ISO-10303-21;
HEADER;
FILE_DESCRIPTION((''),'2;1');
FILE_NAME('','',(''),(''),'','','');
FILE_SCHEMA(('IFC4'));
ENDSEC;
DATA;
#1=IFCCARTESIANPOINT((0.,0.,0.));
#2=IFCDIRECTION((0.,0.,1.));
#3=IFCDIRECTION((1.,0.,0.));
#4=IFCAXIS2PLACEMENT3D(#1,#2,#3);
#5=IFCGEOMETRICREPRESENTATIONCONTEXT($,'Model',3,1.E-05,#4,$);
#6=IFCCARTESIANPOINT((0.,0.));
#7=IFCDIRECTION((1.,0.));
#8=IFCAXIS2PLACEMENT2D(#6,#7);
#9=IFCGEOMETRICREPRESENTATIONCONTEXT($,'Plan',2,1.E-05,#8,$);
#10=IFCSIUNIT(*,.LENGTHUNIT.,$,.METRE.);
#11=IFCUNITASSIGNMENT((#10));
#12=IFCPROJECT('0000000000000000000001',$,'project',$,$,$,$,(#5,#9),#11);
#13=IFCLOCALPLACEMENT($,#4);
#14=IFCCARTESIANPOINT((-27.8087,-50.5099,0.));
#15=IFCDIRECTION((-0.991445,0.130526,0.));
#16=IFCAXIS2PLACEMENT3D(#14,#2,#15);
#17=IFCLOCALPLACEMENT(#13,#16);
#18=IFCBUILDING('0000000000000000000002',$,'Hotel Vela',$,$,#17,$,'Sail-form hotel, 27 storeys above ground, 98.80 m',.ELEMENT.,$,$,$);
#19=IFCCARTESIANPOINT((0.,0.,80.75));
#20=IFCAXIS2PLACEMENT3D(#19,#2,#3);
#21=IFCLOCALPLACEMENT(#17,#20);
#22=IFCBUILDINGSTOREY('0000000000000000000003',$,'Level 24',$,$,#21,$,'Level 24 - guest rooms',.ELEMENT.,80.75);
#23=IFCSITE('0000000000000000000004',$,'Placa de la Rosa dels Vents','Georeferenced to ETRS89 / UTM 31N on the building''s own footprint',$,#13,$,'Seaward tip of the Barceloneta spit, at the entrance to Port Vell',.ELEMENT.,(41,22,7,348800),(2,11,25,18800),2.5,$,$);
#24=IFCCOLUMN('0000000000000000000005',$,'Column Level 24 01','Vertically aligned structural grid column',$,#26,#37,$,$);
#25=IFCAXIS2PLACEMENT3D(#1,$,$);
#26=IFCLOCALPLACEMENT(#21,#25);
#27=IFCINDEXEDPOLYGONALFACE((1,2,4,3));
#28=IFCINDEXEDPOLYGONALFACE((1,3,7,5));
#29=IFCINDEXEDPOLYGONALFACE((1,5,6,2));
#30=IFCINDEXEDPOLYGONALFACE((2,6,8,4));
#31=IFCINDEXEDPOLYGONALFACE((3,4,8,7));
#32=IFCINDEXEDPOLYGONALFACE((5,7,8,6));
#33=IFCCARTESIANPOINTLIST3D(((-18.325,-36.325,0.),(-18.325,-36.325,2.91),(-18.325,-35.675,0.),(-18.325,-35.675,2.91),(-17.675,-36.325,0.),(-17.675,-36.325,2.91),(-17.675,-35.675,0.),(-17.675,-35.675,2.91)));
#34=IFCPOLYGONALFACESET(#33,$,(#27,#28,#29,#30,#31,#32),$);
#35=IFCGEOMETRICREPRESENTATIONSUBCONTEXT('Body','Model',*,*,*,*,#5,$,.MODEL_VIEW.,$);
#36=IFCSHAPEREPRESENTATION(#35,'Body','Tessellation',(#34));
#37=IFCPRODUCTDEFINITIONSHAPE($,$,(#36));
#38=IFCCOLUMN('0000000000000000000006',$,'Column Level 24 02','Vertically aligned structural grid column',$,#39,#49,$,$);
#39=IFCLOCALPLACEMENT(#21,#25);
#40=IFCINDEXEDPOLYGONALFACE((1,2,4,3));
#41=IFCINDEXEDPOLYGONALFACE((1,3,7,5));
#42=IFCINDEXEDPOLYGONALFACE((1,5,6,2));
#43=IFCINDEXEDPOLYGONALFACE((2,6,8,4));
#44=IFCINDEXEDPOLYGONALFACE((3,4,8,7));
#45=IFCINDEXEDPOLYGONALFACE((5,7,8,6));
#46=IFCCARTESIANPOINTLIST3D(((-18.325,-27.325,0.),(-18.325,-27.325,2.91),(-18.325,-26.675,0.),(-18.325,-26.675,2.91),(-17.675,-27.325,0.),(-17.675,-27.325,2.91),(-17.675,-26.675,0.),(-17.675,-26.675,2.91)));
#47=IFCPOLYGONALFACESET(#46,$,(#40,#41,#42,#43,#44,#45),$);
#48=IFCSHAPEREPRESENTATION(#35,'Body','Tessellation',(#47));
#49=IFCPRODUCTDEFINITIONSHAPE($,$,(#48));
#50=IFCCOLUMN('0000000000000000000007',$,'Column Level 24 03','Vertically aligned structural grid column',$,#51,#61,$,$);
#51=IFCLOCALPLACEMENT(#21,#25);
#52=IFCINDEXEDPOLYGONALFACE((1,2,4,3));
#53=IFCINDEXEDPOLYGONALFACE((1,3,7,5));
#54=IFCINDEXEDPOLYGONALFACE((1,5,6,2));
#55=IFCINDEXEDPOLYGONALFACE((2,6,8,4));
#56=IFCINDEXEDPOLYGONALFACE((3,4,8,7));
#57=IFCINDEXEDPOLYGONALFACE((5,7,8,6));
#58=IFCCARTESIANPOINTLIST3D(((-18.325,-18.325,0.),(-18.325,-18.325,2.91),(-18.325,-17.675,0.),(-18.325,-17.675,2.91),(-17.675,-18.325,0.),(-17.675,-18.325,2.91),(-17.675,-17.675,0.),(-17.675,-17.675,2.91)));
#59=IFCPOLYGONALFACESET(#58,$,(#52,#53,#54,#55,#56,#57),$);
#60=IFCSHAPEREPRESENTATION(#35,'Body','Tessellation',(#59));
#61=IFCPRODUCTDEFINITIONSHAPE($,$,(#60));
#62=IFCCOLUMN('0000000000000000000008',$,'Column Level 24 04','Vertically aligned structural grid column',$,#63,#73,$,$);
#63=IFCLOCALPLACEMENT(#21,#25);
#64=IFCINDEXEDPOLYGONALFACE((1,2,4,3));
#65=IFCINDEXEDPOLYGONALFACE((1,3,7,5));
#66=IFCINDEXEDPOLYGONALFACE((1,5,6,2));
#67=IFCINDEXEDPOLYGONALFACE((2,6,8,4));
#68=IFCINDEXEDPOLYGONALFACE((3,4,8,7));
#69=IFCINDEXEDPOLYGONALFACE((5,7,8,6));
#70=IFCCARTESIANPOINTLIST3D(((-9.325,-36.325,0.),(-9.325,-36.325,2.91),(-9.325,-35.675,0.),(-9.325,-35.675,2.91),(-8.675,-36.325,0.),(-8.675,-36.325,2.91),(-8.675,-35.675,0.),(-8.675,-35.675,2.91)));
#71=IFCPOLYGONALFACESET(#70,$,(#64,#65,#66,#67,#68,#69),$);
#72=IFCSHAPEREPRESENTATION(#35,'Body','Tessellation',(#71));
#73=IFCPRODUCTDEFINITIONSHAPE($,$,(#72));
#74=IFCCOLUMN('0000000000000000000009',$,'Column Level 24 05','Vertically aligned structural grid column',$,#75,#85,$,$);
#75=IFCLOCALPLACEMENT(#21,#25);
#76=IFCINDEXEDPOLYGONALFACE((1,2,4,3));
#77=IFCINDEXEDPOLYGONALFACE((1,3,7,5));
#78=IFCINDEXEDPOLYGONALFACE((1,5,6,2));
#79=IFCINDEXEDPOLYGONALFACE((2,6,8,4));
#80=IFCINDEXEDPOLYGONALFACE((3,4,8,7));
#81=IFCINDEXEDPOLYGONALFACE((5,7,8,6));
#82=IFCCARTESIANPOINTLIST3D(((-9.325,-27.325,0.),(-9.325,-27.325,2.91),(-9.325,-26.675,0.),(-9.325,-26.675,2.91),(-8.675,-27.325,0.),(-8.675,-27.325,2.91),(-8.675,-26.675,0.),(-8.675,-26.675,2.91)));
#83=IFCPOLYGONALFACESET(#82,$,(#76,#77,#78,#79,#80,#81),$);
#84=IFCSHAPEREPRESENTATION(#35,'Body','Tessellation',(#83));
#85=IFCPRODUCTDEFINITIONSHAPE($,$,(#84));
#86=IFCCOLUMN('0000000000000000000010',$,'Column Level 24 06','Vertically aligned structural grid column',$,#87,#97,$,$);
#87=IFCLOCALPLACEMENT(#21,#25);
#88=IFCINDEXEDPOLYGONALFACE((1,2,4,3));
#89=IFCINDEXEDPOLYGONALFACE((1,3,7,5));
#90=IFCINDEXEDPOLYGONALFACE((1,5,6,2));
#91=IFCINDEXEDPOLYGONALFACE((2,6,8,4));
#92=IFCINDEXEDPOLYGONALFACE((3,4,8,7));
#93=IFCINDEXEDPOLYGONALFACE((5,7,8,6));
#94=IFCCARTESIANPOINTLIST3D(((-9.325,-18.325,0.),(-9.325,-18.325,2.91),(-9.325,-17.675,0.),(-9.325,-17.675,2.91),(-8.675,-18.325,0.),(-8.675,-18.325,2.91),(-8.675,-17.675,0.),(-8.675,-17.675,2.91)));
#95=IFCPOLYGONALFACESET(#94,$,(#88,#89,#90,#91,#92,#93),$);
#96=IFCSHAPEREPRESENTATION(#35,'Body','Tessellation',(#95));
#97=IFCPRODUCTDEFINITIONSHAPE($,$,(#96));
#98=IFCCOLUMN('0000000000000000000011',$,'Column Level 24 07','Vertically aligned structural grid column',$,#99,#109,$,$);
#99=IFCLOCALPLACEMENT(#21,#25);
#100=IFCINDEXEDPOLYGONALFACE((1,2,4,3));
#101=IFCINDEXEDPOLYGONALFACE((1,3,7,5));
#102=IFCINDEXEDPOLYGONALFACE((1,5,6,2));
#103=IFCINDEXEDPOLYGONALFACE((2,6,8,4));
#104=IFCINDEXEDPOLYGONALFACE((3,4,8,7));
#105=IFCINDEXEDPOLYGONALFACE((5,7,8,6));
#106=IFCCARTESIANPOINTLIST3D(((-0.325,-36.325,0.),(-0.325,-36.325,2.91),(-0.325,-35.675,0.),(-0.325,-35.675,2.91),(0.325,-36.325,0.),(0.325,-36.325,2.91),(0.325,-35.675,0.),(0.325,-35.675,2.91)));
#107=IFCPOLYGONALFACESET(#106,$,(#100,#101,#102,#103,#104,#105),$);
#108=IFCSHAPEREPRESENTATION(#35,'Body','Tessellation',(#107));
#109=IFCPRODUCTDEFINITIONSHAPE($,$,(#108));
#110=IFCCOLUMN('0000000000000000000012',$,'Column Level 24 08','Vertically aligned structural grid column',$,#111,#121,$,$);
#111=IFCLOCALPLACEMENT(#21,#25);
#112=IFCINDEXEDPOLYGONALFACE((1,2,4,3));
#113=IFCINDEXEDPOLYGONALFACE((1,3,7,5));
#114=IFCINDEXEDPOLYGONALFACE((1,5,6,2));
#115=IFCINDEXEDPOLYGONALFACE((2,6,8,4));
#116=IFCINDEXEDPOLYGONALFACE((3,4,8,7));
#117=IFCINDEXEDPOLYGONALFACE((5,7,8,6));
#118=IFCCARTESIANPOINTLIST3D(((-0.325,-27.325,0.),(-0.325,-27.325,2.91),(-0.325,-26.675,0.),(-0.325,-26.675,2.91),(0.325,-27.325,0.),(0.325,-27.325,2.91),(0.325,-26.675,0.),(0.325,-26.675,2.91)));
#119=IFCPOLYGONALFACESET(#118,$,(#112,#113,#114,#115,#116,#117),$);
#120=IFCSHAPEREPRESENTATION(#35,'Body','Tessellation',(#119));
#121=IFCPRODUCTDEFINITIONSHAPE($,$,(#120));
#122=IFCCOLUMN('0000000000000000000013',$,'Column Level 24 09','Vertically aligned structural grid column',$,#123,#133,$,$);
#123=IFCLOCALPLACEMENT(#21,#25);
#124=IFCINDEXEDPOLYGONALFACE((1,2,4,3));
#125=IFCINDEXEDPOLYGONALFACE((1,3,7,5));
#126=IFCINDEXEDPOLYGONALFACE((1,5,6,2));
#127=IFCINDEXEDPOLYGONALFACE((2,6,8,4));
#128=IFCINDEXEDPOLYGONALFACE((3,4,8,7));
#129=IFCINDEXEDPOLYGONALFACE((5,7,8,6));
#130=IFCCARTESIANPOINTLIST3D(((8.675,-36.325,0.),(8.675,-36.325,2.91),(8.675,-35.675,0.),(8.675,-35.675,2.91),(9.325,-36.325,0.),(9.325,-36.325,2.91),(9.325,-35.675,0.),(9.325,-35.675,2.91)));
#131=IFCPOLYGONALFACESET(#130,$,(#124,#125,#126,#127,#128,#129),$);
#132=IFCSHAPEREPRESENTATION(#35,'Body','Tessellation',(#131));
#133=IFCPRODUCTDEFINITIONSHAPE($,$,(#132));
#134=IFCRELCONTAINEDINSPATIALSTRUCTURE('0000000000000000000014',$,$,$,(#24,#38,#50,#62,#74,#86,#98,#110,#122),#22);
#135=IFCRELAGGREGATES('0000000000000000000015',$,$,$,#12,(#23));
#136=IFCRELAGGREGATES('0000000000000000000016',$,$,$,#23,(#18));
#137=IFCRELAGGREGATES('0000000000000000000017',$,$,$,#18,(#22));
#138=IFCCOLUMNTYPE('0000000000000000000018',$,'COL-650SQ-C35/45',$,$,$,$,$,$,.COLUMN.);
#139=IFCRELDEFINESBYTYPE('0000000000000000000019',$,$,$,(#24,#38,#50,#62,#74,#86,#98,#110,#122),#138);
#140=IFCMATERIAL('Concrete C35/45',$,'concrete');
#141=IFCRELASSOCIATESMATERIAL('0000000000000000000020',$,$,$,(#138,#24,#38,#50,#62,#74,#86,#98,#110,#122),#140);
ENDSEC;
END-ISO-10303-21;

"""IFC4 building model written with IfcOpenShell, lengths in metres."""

from ifc_helpers import new_model, si_unit, frame, origin_with_axes, origin_2d_with_axis, place, context, subcontext, project, spatial, line, indexed_curve, rectangle, outline, extrude, material, material_profile, profile_set, profile_usage, type_object, element, save


model = new_model("IFC4")

# Units and contexts
model_context = context("Model", 3, precision=1e-05, world=origin_with_axes())
plan_context = context("Plan", 2, precision=1e-05, world=origin_2d_with_axis())
body_context = subcontext(model_context, "Body", "Model", "MODEL_VIEW")
ifc_project = project(units=[si_unit("LENGTHUNIT", "METRE")], contexts=[model_context, plan_context])

# Site, building, storey
site_placement = place(None, origin_with_axes())
site = spatial("IfcSite", under=ifc_project, at=site_placement, Name="Placa de la Rosa dels Vents", Description="Georeferenced to ETRS89 / UTM 31N on the building's own footprint", LongName="Seaward tip of the Barceloneta spit, at the entrance to Port Vell", CompositionType="ELEMENT", RefLatitude=(41, 22, 7, 348800), RefLongitude=(2, 11, 25, 18800), RefElevation=2.5)
building_placement = place(site_placement, frame((-27.8087, -50.5099, 0.0), z_axis=(0.0, 0.0, 1.0), x_axis=(-0.991445, 0.130526, 0.0)))
building = spatial("IfcBuilding", under=site, at=building_placement, Name="Hotel Vela", LongName="Sail-form hotel, 27 storeys above ground, 98.80 m", CompositionType="ELEMENT")
storey_placement = place(building_placement, frame((0.0, 0.0, 80.75), z_axis=(0.0, 0.0, 1.0), x_axis=(1.0, 0.0, 0.0)))
storey = spatial("IfcBuildingStorey", under=building, at=storey_placement, Name="Level 24", LongName="Level 24 - guest rooms", CompositionType="ELEMENT", Elevation=80.75)

# Columns
ifc_material = material(Name="Concrete C35/45", Category="concrete")
ifc_material_profile = material_profile(ifc_material, rectangle(XDim=0.65, YDim=0.65))
ifc_profile_set = profile_set([ifc_material_profile], Name="COL-650SQ-C35/45")
ifc_profile_usage_1 = profile_usage(ifc_profile_set)
column_type = type_object("IfcColumnType", Name="COL-650SQ-C35/45", PredefinedType="COLUMN", material=ifc_profile_set)
column_1_placement = place(storey_placement, frame((-18.325, -36.325, 0.0), z_axis=(0.0, 0.0, 1.0), x_axis=(1.0, 0.0, 0.0)))
element("IfcColumn", 1, at=column_1_placement, inside=storey, type_object=column_type, material=ifc_profile_usage_1, Name="Column Level 24 01", Description="Vertically aligned structural grid column", context=body_context, shape_type="SweptSolid", body=[
    extrude(outline(indexed_curve([(0.0, 0.0), (0.65, 0.0), (0.65, 0.65), (0.0, 0.65)], segments=[line(1, 2, 3, 4, 1)])), origin_with_axes(), (0.0, 0.0, 1.0), 2.91),
])
ifc_profile_usage_2 = profile_usage(ifc_profile_set)
column_2_placement = place(storey_placement, frame((-18.325, -27.325, 0.0), z_axis=(0.0, 0.0, 1.0), x_axis=(1.0, 0.0, 0.0)))
element("IfcColumn", 2, at=column_2_placement, inside=storey, type_object=column_type, material=ifc_profile_usage_2, Name="Column Level 24 02", Description="Vertically aligned structural grid column", context=body_context, shape_type="SweptSolid", body=[
    extrude(outline(indexed_curve([(0.0, 0.0), (0.65, 0.0), (0.65, 0.65), (0.0, 0.65)], segments=[line(1, 2, 3, 4, 1)])), origin_with_axes(), (0.0, 0.0, 1.0), 2.91),
])
ifc_profile_usage_3 = profile_usage(ifc_profile_set)
column_3_placement = place(storey_placement, frame((-18.325, -18.325, 0.0), z_axis=(0.0, 0.0, 1.0), x_axis=(1.0, 0.0, 0.0)))
element("IfcColumn", 3, at=column_3_placement, inside=storey, type_object=column_type, material=ifc_profile_usage_3, Name="Column Level 24 03", Description="Vertically aligned structural grid column", context=body_context, shape_type="SweptSolid", body=[
    extrude(outline(indexed_curve([(0.0, 0.0), (0.65, 0.0), (0.65, 0.65), (0.0, 0.65)], segments=[line(1, 2, 3, 4, 1)])), origin_with_axes(), (0.0, 0.0, 1.0), 2.91),
])
ifc_profile_usage_4 = profile_usage(ifc_profile_set)
column_4_placement = place(storey_placement, frame((-9.325, -36.325, 0.0), z_axis=(0.0, 0.0, 1.0), x_axis=(1.0, 0.0, 0.0)))
element("IfcColumn", 4, at=column_4_placement, inside=storey, type_object=column_type, material=ifc_profile_usage_4, Name="Column Level 24 04", Description="Vertically aligned structural grid column", context=body_context, shape_type="SweptSolid", body=[
    extrude(outline(indexed_curve([(0.0, 0.0), (0.65, 0.0), (0.65, 0.65), (0.0, 0.65)], segments=[line(1, 2, 3, 4, 1)])), origin_with_axes(), (0.0, 0.0, 1.0), 2.91),
])
ifc_profile_usage_5 = profile_usage(ifc_profile_set)
column_5_placement = place(storey_placement, frame((-9.325, -27.325, 0.0), z_axis=(0.0, 0.0, 1.0), x_axis=(1.0, 0.0, 0.0)))
element("IfcColumn", 5, at=column_5_placement, inside=storey, type_object=column_type, material=ifc_profile_usage_5, Name="Column Level 24 05", Description="Vertically aligned structural grid column", context=body_context, shape_type="SweptSolid", body=[
    extrude(outline(indexed_curve([(0.0, 0.0), (0.65, 0.0), (0.65, 0.65), (0.0, 0.65)], segments=[line(1, 2, 3, 4, 1)])), origin_with_axes(), (0.0, 0.0, 1.0), 2.91),
])
ifc_profile_usage_6 = profile_usage(ifc_profile_set)
column_6_placement = place(storey_placement, frame((-9.325, -18.325, 0.0), z_axis=(0.0, 0.0, 1.0), x_axis=(1.0, 0.0, 0.0)))
element("IfcColumn", 6, at=column_6_placement, inside=storey, type_object=column_type, material=ifc_profile_usage_6, Name="Column Level 24 06", Description="Vertically aligned structural grid column", context=body_context, shape_type="SweptSolid", body=[
    extrude(outline(indexed_curve([(0.0, 0.0), (0.65, 0.0), (0.65, 0.65), (0.0, 0.65)], segments=[line(1, 2, 3, 4, 1)])), origin_with_axes(), (0.0, 0.0, 1.0), 2.91),
])
ifc_profile_usage_7 = profile_usage(ifc_profile_set)
column_7_placement = place(storey_placement, frame((-0.325, -36.325, 0.0), z_axis=(0.0, 0.0, 1.0), x_axis=(1.0, 0.0, 0.0)))
element("IfcColumn", 7, at=column_7_placement, inside=storey, type_object=column_type, material=ifc_profile_usage_7, Name="Column Level 24 07", Description="Vertically aligned structural grid column", context=body_context, shape_type="SweptSolid", body=[
    extrude(outline(indexed_curve([(0.0, 0.0), (0.65, 0.0), (0.65, 0.65), (0.0, 0.65)], segments=[line(1, 2, 3, 4, 1)])), origin_with_axes(), (0.0, 0.0, 1.0), 2.91),
])
ifc_profile_usage_8 = profile_usage(ifc_profile_set)
column_8_placement = place(storey_placement, frame((-0.325, -27.325, 0.0), z_axis=(0.0, 0.0, 1.0), x_axis=(1.0, 0.0, 0.0)))
element("IfcColumn", 8, at=column_8_placement, inside=storey, type_object=column_type, material=ifc_profile_usage_8, Name="Column Level 24 08", Description="Vertically aligned structural grid column", context=body_context, shape_type="SweptSolid", body=[
    extrude(outline(indexed_curve([(0.0, 0.0), (0.65, 0.0), (0.65, 0.65), (0.0, 0.65)], segments=[line(1, 2, 3, 4, 1)])), origin_with_axes(), (0.0, 0.0, 1.0), 2.91),
])
ifc_profile_usage_9 = profile_usage(ifc_profile_set)
column_9_placement = place(storey_placement, frame((8.675, -36.325, 0.0), z_axis=(0.0, 0.0, 1.0), x_axis=(1.0, 0.0, 0.0)))
element("IfcColumn", 9, at=column_9_placement, inside=storey, type_object=column_type, material=ifc_profile_usage_9, Name="Column Level 24 09", Description="Vertically aligned structural grid column", context=body_context, shape_type="SweptSolid", body=[
    extrude(outline(indexed_curve([(0.0, 0.0), (0.65, 0.0), (0.65, 0.65), (0.0, 0.65)], segments=[line(1, 2, 3, 4, 1)])), origin_with_axes(), (0.0, 0.0, 1.0), 2.91),
])

save(model, "model.ifc")
